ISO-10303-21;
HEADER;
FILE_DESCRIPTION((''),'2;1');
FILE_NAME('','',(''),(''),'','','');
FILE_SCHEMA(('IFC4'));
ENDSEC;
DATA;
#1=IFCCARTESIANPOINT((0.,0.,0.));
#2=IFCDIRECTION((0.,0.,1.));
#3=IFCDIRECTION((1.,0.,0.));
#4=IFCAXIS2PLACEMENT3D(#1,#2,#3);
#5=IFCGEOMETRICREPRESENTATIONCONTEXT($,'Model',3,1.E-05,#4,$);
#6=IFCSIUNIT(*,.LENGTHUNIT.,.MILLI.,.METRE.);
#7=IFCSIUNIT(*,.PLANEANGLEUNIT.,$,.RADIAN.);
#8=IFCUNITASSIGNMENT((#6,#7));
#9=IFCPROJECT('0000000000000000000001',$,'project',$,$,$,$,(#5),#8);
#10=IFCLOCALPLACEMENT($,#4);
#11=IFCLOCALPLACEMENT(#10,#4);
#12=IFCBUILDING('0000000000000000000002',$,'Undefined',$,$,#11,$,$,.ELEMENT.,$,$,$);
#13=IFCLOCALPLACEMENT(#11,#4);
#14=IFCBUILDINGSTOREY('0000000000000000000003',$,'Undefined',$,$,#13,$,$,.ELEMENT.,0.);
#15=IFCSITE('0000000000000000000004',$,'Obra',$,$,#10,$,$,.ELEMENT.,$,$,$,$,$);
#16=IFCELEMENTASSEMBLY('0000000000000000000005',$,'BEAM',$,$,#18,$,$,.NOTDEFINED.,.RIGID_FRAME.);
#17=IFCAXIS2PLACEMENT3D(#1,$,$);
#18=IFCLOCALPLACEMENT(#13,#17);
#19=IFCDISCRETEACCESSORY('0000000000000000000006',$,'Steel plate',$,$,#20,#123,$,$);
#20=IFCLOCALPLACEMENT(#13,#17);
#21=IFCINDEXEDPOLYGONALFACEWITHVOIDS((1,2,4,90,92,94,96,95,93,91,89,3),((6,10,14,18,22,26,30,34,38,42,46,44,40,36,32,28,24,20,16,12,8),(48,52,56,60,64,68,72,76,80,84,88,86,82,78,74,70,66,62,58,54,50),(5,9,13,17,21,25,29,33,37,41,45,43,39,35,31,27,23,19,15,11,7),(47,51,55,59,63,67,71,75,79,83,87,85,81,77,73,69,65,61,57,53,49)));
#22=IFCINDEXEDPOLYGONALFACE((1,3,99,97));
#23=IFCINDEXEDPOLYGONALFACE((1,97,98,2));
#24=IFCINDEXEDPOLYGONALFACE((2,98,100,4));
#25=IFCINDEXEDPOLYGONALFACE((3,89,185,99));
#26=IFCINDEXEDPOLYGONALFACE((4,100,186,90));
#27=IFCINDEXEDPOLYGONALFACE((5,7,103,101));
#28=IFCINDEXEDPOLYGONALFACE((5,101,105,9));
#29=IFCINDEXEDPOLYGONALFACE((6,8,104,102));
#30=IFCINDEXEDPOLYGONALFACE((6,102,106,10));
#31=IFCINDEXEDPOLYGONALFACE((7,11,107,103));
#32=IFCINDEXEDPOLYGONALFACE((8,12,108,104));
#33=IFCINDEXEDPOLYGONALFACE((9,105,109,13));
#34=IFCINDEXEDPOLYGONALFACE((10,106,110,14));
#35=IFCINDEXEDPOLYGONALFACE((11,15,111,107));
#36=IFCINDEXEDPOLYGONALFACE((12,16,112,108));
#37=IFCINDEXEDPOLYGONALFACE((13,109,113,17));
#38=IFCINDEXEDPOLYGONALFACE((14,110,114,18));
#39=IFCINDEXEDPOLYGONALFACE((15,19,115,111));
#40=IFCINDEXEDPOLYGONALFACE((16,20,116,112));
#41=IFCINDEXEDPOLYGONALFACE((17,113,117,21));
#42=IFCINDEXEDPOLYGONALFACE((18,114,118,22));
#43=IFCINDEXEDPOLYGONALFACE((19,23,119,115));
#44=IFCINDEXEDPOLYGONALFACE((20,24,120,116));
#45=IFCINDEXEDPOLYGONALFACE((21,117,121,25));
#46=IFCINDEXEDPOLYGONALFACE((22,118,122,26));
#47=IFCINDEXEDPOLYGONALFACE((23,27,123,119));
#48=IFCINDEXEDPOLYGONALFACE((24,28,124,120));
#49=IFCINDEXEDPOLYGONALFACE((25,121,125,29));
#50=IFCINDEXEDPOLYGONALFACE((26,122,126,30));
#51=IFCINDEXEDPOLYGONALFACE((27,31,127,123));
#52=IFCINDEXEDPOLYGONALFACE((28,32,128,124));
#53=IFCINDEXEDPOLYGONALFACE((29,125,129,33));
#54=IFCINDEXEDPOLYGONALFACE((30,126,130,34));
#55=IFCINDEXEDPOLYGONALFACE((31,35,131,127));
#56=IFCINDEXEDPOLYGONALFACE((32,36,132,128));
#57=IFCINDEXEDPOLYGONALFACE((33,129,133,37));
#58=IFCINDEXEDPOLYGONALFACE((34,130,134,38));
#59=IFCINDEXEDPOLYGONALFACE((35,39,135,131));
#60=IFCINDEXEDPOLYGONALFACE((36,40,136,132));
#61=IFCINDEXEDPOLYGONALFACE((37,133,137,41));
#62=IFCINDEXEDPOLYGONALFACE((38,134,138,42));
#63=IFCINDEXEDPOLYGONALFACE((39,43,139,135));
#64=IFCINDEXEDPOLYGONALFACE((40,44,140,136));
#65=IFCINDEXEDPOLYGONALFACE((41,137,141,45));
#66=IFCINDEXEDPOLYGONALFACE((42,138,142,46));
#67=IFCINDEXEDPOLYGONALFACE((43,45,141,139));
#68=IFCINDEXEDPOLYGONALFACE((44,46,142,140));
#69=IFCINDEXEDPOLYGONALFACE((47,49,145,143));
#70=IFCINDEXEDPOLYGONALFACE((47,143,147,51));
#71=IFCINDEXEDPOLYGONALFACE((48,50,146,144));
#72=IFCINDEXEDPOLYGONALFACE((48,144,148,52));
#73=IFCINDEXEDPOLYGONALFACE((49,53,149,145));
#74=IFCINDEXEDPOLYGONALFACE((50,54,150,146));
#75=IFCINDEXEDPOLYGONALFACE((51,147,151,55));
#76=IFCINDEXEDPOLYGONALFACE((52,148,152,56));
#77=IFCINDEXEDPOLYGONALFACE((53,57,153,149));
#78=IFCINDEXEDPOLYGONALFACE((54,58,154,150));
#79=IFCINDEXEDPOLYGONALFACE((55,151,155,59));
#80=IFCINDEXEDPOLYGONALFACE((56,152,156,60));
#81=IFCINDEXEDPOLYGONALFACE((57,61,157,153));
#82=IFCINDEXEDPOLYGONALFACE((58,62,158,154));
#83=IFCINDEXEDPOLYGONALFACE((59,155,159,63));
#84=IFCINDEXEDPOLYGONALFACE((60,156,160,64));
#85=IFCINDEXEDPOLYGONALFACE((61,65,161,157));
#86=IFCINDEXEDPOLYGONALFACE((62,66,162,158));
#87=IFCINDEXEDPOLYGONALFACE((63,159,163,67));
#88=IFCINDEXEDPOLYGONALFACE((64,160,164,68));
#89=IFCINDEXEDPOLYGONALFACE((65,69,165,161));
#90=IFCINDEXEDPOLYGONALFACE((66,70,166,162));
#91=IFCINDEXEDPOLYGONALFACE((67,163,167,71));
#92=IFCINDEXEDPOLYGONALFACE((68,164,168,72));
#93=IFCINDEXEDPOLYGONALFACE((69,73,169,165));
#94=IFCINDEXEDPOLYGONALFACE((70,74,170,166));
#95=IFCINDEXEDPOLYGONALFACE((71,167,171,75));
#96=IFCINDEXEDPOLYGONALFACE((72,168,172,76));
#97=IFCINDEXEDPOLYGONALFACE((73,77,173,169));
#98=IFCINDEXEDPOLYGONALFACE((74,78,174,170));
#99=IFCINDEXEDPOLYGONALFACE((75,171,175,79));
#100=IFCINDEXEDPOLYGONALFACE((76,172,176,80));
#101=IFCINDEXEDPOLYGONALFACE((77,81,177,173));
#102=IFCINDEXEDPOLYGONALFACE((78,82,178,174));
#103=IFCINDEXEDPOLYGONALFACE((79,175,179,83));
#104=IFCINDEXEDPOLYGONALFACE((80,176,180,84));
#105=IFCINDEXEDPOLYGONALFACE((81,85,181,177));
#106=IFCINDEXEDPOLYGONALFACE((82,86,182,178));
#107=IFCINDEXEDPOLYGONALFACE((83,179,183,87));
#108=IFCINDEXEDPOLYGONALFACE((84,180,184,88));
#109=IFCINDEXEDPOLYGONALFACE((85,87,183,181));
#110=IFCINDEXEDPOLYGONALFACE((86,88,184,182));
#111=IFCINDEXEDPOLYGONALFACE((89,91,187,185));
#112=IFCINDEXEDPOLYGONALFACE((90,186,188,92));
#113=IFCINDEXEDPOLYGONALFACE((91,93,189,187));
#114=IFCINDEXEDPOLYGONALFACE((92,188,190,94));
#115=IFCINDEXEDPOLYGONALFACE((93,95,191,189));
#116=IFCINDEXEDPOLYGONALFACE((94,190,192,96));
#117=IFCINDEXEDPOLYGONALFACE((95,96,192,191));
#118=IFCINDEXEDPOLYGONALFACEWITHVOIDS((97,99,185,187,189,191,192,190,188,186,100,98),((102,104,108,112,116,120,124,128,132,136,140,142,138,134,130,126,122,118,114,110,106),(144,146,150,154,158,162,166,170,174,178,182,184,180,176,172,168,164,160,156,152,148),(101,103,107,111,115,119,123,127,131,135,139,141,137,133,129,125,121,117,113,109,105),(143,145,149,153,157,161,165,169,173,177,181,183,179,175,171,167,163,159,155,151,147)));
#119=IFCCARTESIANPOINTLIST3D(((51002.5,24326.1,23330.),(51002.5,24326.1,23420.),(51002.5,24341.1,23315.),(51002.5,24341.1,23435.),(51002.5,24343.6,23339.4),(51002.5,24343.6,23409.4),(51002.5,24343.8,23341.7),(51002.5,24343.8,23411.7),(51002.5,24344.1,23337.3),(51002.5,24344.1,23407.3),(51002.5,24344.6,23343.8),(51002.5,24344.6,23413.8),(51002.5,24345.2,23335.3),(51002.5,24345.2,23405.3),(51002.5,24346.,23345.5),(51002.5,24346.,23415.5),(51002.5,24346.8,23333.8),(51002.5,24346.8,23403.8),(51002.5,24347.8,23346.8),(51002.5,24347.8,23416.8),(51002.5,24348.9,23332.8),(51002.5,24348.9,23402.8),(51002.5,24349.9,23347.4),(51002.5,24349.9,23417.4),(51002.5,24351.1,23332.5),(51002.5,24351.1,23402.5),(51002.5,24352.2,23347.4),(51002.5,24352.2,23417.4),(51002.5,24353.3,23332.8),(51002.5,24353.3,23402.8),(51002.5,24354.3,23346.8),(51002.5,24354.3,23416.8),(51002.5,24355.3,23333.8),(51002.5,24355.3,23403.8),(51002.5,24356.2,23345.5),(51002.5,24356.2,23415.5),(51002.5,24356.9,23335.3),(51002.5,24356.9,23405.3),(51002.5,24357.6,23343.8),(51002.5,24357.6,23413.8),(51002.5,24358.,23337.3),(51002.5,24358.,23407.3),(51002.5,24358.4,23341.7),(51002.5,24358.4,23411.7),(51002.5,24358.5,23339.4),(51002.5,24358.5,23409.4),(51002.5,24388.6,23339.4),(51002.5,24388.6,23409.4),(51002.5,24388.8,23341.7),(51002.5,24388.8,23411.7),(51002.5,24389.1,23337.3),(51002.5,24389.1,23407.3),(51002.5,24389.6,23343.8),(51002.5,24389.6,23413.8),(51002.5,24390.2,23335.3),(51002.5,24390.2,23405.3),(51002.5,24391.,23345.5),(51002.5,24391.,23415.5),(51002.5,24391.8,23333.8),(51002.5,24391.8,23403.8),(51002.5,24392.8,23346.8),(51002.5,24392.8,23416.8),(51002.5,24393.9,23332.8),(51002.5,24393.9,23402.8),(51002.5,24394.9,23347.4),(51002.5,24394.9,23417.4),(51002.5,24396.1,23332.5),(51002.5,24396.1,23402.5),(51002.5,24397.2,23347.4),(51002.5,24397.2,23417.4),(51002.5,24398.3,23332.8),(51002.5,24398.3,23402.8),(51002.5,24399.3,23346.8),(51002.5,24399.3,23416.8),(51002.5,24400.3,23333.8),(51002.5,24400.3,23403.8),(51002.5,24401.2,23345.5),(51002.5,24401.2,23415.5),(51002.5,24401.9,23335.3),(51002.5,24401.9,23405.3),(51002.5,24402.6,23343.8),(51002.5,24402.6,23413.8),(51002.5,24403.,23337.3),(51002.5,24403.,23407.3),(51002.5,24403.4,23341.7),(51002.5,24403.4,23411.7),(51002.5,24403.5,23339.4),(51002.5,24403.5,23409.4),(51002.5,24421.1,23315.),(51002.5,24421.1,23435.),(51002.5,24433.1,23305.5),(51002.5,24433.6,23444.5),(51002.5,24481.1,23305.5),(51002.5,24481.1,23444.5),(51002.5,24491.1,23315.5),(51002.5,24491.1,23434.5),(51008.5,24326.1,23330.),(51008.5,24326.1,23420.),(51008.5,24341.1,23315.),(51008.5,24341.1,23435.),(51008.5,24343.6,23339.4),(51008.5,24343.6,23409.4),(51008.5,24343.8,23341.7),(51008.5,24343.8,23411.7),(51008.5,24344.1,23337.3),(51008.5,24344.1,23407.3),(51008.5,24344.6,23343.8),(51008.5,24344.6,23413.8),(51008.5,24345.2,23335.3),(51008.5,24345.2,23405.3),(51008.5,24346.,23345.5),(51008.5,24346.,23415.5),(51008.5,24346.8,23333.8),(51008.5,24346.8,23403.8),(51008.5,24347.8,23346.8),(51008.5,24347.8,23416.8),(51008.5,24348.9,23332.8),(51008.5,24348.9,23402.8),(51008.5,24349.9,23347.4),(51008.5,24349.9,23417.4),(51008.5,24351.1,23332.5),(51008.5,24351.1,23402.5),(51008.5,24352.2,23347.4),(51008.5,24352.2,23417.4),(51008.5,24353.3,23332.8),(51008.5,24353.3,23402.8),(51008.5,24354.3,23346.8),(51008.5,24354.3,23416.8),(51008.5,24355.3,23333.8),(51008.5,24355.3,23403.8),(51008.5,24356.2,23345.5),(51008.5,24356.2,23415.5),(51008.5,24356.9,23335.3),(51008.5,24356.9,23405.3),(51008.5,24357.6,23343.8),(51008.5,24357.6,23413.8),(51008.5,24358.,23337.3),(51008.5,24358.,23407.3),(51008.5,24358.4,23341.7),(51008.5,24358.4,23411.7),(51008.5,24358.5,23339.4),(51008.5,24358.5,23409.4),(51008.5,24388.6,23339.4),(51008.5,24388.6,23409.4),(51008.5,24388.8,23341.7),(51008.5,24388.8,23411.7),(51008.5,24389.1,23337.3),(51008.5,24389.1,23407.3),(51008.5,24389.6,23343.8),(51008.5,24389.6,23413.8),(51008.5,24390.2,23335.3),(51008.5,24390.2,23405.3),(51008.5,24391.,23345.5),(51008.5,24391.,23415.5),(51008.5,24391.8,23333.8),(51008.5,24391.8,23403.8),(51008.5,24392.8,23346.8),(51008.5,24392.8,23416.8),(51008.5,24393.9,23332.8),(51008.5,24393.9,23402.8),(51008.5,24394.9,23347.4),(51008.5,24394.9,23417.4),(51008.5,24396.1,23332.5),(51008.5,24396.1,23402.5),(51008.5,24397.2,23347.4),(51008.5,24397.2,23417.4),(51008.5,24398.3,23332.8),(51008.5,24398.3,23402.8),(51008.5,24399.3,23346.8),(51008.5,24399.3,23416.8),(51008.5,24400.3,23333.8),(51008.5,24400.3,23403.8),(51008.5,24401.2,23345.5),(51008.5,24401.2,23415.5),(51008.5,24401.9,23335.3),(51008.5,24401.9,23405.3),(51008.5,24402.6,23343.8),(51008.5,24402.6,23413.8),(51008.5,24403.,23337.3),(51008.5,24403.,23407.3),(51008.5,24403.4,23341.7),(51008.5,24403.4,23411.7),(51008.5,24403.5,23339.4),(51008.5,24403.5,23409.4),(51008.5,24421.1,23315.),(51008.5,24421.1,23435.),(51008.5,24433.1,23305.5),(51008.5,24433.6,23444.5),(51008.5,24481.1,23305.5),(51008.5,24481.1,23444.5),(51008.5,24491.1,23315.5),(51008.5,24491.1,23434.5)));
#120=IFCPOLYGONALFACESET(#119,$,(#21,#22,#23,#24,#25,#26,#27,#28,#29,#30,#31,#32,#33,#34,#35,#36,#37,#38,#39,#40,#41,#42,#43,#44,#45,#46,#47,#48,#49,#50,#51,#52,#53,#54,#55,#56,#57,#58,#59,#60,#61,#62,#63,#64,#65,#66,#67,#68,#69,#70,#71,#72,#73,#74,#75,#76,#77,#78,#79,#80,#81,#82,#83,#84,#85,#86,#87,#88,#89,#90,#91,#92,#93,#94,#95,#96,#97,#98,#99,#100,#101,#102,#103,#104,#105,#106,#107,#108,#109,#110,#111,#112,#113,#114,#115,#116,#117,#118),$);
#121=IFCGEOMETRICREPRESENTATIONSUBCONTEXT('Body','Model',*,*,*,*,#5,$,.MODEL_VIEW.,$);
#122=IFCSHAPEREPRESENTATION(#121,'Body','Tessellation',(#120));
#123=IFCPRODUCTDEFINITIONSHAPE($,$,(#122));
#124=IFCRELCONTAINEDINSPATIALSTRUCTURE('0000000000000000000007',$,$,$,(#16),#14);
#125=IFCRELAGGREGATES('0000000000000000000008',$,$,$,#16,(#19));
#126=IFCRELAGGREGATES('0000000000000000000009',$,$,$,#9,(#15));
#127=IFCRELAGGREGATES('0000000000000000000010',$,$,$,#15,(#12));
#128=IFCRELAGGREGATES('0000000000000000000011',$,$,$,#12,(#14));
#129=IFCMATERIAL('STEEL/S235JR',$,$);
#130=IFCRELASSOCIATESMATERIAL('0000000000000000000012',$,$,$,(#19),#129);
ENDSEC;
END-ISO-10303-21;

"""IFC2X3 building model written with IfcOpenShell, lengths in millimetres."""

from ifc_helpers import new_model, si_unit, frame, origin_with_axes, origin_2d_with_axis, place, context, subcontext, project, spatial, polyline, circle, outline, extrude, source, transform, mapped, material, element, aggregate, save


model = new_model("IFC2X3")

# Units and contexts
model_context = context("Model", 3, precision=1e-05, world=origin_with_axes())
body_context = subcontext(model_context, "Body", "Model", "MODEL_VIEW")
ifc_project = project(units=[si_unit("LENGTHUNIT", "METRE", prefix="MILLI"), si_unit("PLANEANGLEUNIT", "RADIAN")], contexts=[model_context])

# Site, building, storey
site_placement = place(None, origin_with_axes())
site = spatial("IfcSite", under=ifc_project, at=site_placement, Name="Obra", CompositionType="ELEMENT")
building_placement = place(site_placement, origin_with_axes())
building = spatial("IfcBuilding", under=site, at=building_placement, Name="Undefined", CompositionType="ELEMENT")
storey_placement = place(building_placement, origin_with_axes())
storey = spatial("IfcBuildingStorey", under=building, at=storey_placement, Name="Undefined", CompositionType="ELEMENT", Elevation=0.0)

# Shared definitions
ifc_material_1 = material(Name="STEEL/S235JR")

# Element assembly, discrete accessory, opening
assembly_1_placement = place(storey_placement, origin_with_axes())
assembly_1 = element("IfcElementAssembly", 1, at=assembly_1_placement, inside=storey, Name="BEAM", AssemblyPlace="NOTDEFINED", PredefinedType="RIGID_FRAME")
discrete_accessory_1_placement = place(assembly_1_placement, frame((51005.5, 24491.1, 23315.5), z_axis=(-1.0, 0.0, 0.0), x_axis=(0.0, -0.707107, -0.707107)))
discrete_accessory_1 = element("IfcDiscreteAccessory", 2, at=discrete_accessory_1_placement, material=ifc_material_1, Name="Steel plate", context=body_context, shape_type="SweptSolid", body=[
    extrude(outline(polyline([(0.0, 0.0), (14.1, 0.0), (48.1, 33.9), (49.9, 49.1), (106.4, 105.7), (106.4, 126.9), (42.8, 190.6), (21.6, 190.6), (-35.0, 134.0), (-50.6, 131.9), (-84.1, 98.3), (-84.1, 84.1), (0.0, 0.0)])), frame((0.0, 0.0, -3.0), z_axis=(0.0, 0.0, 1.0), x_axis=(1.0, 0.0, 0.0)), (0.0, 0.0, 1.0), 6.0),
])
shared_shape_1 = source(origin_with_axes(), body_context, "Body", "SweptSolid", [
    extrude(circle(Radius=7.5, at=origin_2d_with_axis()), frame((0.0, 2.4, 0.0), z_axis=(0.0, 1.0, 0.0), x_axis=(1.0, 0.0, 0.0)), (0.0, 0.0, 1.0), 6.2),
])
opening_1_placement = place(assembly_1_placement, frame((51000.0, 24373.6, 23410.0), z_axis=(0.0, -1.0, 0.0), x_axis=(0.0, 0.0, -1.0)))
element("IfcOpeningElement", 3, at=opening_1_placement, cuts=discrete_accessory_1, ObjectType="Opening", context=body_context, shape_type="MappedRepresentation", body=[
    mapped(shared_shape_1, transform((0.0, 0.0, -22.5))),
    mapped(shared_shape_1, transform((70.0, 0.0, -22.5))),
    mapped(shared_shape_1, transform((0.0, 0.0, 22.5))),
    mapped(shared_shape_1, transform((70.0, 0.0, 22.5))),
])

aggregate(assembly_1, [discrete_accessory_1])

save(model, "model.ifc")
